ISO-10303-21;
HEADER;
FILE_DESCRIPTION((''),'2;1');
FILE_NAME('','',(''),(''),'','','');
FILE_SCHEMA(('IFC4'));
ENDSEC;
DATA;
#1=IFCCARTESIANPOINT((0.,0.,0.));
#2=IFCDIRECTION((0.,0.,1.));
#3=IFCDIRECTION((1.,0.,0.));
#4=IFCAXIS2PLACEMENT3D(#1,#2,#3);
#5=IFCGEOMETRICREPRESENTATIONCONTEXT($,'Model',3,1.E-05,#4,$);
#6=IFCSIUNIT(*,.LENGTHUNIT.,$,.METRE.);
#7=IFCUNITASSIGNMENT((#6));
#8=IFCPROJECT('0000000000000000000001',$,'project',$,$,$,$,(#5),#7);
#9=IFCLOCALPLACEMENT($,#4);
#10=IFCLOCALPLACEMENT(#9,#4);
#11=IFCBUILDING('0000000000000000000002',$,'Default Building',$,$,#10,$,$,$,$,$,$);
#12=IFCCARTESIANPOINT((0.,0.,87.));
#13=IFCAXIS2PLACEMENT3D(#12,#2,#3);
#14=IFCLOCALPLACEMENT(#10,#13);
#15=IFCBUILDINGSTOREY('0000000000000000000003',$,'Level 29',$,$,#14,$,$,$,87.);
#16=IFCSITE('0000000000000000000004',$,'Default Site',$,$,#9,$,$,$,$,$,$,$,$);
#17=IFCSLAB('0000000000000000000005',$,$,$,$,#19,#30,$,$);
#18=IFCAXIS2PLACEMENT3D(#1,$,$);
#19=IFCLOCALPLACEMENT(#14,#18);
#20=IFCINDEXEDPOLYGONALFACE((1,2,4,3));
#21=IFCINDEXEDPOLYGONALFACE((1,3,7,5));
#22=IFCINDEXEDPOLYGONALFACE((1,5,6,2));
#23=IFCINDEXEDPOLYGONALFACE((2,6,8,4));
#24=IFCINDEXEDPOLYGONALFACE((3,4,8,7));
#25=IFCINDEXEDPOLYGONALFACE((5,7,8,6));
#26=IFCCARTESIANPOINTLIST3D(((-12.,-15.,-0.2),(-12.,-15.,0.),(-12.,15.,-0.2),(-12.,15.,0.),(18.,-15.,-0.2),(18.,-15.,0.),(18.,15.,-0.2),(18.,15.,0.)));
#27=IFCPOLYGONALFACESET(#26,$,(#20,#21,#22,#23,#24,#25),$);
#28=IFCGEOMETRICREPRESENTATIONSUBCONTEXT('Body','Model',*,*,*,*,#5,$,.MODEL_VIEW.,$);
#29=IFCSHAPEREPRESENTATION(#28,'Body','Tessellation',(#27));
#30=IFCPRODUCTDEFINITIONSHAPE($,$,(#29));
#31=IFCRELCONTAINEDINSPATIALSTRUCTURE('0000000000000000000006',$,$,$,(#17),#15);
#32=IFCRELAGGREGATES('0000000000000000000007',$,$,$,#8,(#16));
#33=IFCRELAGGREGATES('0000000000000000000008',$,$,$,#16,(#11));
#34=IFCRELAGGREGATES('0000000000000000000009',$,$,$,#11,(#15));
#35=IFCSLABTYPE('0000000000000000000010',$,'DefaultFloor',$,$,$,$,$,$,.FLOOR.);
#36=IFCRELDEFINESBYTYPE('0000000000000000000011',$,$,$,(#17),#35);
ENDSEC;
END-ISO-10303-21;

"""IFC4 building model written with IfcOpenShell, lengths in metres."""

from ifc_helpers import new_model, si_unit, frame, origin_with_axes, place, context, subcontext, project, spatial, polyline, outline, extrude, type_object, element, save


model = new_model("IFC4")

# Units and contexts
model_context = context("Model", 3, precision=1e-05, world=origin_with_axes())
body_context = subcontext(model_context, "Body", "Model", "MODEL_VIEW")
ifc_project = project(units=[si_unit("LENGTHUNIT", "METRE")], contexts=[model_context])

# Site, building, storey
site_placement = place(None, origin_with_axes())
site = spatial("IfcSite", under=ifc_project, at=site_placement, Name="Default Site")
building_placement = place(site_placement, origin_with_axes())
building = spatial("IfcBuilding", under=site, at=building_placement, Name="Default Building")
storey_placement = place(building_placement, frame((0.0, 0.0, 87.0), z_axis=(0.0, 0.0, 1.0), x_axis=(1.0, 0.0, 0.0)))
storey = spatial("IfcBuildingStorey", under=building, at=storey_placement, Name="Level 29", Elevation=87.0)

# Slab
slab_type = type_object("IfcSlabType", Name="DefaultFloor", PredefinedType="FLOOR")
slab_placement = place(storey_placement, frame((0.0, 0.0, -87.0), z_axis=(0.0, 0.0, 1.0), x_axis=(1.0, 0.0, 0.0)))
element("IfcSlab", 1, at=slab_placement, inside=storey, type_object=slab_type, context=body_context, shape_type="SweptSolid", body=[
    extrude(outline(polyline([(-12.0, 15.0), (18.0, 15.0), (18.0, -15.0), (-12.0, -15.0), (-12.0, 15.0)])), frame((0.0, 0.0, 87.0), z_axis=(0.0, 0.0, 1.0), x_axis=(1.0, 0.0, 0.0)), (0.0, 0.0, -1.0), 0.2),
])

save(model, "model.ifc")
